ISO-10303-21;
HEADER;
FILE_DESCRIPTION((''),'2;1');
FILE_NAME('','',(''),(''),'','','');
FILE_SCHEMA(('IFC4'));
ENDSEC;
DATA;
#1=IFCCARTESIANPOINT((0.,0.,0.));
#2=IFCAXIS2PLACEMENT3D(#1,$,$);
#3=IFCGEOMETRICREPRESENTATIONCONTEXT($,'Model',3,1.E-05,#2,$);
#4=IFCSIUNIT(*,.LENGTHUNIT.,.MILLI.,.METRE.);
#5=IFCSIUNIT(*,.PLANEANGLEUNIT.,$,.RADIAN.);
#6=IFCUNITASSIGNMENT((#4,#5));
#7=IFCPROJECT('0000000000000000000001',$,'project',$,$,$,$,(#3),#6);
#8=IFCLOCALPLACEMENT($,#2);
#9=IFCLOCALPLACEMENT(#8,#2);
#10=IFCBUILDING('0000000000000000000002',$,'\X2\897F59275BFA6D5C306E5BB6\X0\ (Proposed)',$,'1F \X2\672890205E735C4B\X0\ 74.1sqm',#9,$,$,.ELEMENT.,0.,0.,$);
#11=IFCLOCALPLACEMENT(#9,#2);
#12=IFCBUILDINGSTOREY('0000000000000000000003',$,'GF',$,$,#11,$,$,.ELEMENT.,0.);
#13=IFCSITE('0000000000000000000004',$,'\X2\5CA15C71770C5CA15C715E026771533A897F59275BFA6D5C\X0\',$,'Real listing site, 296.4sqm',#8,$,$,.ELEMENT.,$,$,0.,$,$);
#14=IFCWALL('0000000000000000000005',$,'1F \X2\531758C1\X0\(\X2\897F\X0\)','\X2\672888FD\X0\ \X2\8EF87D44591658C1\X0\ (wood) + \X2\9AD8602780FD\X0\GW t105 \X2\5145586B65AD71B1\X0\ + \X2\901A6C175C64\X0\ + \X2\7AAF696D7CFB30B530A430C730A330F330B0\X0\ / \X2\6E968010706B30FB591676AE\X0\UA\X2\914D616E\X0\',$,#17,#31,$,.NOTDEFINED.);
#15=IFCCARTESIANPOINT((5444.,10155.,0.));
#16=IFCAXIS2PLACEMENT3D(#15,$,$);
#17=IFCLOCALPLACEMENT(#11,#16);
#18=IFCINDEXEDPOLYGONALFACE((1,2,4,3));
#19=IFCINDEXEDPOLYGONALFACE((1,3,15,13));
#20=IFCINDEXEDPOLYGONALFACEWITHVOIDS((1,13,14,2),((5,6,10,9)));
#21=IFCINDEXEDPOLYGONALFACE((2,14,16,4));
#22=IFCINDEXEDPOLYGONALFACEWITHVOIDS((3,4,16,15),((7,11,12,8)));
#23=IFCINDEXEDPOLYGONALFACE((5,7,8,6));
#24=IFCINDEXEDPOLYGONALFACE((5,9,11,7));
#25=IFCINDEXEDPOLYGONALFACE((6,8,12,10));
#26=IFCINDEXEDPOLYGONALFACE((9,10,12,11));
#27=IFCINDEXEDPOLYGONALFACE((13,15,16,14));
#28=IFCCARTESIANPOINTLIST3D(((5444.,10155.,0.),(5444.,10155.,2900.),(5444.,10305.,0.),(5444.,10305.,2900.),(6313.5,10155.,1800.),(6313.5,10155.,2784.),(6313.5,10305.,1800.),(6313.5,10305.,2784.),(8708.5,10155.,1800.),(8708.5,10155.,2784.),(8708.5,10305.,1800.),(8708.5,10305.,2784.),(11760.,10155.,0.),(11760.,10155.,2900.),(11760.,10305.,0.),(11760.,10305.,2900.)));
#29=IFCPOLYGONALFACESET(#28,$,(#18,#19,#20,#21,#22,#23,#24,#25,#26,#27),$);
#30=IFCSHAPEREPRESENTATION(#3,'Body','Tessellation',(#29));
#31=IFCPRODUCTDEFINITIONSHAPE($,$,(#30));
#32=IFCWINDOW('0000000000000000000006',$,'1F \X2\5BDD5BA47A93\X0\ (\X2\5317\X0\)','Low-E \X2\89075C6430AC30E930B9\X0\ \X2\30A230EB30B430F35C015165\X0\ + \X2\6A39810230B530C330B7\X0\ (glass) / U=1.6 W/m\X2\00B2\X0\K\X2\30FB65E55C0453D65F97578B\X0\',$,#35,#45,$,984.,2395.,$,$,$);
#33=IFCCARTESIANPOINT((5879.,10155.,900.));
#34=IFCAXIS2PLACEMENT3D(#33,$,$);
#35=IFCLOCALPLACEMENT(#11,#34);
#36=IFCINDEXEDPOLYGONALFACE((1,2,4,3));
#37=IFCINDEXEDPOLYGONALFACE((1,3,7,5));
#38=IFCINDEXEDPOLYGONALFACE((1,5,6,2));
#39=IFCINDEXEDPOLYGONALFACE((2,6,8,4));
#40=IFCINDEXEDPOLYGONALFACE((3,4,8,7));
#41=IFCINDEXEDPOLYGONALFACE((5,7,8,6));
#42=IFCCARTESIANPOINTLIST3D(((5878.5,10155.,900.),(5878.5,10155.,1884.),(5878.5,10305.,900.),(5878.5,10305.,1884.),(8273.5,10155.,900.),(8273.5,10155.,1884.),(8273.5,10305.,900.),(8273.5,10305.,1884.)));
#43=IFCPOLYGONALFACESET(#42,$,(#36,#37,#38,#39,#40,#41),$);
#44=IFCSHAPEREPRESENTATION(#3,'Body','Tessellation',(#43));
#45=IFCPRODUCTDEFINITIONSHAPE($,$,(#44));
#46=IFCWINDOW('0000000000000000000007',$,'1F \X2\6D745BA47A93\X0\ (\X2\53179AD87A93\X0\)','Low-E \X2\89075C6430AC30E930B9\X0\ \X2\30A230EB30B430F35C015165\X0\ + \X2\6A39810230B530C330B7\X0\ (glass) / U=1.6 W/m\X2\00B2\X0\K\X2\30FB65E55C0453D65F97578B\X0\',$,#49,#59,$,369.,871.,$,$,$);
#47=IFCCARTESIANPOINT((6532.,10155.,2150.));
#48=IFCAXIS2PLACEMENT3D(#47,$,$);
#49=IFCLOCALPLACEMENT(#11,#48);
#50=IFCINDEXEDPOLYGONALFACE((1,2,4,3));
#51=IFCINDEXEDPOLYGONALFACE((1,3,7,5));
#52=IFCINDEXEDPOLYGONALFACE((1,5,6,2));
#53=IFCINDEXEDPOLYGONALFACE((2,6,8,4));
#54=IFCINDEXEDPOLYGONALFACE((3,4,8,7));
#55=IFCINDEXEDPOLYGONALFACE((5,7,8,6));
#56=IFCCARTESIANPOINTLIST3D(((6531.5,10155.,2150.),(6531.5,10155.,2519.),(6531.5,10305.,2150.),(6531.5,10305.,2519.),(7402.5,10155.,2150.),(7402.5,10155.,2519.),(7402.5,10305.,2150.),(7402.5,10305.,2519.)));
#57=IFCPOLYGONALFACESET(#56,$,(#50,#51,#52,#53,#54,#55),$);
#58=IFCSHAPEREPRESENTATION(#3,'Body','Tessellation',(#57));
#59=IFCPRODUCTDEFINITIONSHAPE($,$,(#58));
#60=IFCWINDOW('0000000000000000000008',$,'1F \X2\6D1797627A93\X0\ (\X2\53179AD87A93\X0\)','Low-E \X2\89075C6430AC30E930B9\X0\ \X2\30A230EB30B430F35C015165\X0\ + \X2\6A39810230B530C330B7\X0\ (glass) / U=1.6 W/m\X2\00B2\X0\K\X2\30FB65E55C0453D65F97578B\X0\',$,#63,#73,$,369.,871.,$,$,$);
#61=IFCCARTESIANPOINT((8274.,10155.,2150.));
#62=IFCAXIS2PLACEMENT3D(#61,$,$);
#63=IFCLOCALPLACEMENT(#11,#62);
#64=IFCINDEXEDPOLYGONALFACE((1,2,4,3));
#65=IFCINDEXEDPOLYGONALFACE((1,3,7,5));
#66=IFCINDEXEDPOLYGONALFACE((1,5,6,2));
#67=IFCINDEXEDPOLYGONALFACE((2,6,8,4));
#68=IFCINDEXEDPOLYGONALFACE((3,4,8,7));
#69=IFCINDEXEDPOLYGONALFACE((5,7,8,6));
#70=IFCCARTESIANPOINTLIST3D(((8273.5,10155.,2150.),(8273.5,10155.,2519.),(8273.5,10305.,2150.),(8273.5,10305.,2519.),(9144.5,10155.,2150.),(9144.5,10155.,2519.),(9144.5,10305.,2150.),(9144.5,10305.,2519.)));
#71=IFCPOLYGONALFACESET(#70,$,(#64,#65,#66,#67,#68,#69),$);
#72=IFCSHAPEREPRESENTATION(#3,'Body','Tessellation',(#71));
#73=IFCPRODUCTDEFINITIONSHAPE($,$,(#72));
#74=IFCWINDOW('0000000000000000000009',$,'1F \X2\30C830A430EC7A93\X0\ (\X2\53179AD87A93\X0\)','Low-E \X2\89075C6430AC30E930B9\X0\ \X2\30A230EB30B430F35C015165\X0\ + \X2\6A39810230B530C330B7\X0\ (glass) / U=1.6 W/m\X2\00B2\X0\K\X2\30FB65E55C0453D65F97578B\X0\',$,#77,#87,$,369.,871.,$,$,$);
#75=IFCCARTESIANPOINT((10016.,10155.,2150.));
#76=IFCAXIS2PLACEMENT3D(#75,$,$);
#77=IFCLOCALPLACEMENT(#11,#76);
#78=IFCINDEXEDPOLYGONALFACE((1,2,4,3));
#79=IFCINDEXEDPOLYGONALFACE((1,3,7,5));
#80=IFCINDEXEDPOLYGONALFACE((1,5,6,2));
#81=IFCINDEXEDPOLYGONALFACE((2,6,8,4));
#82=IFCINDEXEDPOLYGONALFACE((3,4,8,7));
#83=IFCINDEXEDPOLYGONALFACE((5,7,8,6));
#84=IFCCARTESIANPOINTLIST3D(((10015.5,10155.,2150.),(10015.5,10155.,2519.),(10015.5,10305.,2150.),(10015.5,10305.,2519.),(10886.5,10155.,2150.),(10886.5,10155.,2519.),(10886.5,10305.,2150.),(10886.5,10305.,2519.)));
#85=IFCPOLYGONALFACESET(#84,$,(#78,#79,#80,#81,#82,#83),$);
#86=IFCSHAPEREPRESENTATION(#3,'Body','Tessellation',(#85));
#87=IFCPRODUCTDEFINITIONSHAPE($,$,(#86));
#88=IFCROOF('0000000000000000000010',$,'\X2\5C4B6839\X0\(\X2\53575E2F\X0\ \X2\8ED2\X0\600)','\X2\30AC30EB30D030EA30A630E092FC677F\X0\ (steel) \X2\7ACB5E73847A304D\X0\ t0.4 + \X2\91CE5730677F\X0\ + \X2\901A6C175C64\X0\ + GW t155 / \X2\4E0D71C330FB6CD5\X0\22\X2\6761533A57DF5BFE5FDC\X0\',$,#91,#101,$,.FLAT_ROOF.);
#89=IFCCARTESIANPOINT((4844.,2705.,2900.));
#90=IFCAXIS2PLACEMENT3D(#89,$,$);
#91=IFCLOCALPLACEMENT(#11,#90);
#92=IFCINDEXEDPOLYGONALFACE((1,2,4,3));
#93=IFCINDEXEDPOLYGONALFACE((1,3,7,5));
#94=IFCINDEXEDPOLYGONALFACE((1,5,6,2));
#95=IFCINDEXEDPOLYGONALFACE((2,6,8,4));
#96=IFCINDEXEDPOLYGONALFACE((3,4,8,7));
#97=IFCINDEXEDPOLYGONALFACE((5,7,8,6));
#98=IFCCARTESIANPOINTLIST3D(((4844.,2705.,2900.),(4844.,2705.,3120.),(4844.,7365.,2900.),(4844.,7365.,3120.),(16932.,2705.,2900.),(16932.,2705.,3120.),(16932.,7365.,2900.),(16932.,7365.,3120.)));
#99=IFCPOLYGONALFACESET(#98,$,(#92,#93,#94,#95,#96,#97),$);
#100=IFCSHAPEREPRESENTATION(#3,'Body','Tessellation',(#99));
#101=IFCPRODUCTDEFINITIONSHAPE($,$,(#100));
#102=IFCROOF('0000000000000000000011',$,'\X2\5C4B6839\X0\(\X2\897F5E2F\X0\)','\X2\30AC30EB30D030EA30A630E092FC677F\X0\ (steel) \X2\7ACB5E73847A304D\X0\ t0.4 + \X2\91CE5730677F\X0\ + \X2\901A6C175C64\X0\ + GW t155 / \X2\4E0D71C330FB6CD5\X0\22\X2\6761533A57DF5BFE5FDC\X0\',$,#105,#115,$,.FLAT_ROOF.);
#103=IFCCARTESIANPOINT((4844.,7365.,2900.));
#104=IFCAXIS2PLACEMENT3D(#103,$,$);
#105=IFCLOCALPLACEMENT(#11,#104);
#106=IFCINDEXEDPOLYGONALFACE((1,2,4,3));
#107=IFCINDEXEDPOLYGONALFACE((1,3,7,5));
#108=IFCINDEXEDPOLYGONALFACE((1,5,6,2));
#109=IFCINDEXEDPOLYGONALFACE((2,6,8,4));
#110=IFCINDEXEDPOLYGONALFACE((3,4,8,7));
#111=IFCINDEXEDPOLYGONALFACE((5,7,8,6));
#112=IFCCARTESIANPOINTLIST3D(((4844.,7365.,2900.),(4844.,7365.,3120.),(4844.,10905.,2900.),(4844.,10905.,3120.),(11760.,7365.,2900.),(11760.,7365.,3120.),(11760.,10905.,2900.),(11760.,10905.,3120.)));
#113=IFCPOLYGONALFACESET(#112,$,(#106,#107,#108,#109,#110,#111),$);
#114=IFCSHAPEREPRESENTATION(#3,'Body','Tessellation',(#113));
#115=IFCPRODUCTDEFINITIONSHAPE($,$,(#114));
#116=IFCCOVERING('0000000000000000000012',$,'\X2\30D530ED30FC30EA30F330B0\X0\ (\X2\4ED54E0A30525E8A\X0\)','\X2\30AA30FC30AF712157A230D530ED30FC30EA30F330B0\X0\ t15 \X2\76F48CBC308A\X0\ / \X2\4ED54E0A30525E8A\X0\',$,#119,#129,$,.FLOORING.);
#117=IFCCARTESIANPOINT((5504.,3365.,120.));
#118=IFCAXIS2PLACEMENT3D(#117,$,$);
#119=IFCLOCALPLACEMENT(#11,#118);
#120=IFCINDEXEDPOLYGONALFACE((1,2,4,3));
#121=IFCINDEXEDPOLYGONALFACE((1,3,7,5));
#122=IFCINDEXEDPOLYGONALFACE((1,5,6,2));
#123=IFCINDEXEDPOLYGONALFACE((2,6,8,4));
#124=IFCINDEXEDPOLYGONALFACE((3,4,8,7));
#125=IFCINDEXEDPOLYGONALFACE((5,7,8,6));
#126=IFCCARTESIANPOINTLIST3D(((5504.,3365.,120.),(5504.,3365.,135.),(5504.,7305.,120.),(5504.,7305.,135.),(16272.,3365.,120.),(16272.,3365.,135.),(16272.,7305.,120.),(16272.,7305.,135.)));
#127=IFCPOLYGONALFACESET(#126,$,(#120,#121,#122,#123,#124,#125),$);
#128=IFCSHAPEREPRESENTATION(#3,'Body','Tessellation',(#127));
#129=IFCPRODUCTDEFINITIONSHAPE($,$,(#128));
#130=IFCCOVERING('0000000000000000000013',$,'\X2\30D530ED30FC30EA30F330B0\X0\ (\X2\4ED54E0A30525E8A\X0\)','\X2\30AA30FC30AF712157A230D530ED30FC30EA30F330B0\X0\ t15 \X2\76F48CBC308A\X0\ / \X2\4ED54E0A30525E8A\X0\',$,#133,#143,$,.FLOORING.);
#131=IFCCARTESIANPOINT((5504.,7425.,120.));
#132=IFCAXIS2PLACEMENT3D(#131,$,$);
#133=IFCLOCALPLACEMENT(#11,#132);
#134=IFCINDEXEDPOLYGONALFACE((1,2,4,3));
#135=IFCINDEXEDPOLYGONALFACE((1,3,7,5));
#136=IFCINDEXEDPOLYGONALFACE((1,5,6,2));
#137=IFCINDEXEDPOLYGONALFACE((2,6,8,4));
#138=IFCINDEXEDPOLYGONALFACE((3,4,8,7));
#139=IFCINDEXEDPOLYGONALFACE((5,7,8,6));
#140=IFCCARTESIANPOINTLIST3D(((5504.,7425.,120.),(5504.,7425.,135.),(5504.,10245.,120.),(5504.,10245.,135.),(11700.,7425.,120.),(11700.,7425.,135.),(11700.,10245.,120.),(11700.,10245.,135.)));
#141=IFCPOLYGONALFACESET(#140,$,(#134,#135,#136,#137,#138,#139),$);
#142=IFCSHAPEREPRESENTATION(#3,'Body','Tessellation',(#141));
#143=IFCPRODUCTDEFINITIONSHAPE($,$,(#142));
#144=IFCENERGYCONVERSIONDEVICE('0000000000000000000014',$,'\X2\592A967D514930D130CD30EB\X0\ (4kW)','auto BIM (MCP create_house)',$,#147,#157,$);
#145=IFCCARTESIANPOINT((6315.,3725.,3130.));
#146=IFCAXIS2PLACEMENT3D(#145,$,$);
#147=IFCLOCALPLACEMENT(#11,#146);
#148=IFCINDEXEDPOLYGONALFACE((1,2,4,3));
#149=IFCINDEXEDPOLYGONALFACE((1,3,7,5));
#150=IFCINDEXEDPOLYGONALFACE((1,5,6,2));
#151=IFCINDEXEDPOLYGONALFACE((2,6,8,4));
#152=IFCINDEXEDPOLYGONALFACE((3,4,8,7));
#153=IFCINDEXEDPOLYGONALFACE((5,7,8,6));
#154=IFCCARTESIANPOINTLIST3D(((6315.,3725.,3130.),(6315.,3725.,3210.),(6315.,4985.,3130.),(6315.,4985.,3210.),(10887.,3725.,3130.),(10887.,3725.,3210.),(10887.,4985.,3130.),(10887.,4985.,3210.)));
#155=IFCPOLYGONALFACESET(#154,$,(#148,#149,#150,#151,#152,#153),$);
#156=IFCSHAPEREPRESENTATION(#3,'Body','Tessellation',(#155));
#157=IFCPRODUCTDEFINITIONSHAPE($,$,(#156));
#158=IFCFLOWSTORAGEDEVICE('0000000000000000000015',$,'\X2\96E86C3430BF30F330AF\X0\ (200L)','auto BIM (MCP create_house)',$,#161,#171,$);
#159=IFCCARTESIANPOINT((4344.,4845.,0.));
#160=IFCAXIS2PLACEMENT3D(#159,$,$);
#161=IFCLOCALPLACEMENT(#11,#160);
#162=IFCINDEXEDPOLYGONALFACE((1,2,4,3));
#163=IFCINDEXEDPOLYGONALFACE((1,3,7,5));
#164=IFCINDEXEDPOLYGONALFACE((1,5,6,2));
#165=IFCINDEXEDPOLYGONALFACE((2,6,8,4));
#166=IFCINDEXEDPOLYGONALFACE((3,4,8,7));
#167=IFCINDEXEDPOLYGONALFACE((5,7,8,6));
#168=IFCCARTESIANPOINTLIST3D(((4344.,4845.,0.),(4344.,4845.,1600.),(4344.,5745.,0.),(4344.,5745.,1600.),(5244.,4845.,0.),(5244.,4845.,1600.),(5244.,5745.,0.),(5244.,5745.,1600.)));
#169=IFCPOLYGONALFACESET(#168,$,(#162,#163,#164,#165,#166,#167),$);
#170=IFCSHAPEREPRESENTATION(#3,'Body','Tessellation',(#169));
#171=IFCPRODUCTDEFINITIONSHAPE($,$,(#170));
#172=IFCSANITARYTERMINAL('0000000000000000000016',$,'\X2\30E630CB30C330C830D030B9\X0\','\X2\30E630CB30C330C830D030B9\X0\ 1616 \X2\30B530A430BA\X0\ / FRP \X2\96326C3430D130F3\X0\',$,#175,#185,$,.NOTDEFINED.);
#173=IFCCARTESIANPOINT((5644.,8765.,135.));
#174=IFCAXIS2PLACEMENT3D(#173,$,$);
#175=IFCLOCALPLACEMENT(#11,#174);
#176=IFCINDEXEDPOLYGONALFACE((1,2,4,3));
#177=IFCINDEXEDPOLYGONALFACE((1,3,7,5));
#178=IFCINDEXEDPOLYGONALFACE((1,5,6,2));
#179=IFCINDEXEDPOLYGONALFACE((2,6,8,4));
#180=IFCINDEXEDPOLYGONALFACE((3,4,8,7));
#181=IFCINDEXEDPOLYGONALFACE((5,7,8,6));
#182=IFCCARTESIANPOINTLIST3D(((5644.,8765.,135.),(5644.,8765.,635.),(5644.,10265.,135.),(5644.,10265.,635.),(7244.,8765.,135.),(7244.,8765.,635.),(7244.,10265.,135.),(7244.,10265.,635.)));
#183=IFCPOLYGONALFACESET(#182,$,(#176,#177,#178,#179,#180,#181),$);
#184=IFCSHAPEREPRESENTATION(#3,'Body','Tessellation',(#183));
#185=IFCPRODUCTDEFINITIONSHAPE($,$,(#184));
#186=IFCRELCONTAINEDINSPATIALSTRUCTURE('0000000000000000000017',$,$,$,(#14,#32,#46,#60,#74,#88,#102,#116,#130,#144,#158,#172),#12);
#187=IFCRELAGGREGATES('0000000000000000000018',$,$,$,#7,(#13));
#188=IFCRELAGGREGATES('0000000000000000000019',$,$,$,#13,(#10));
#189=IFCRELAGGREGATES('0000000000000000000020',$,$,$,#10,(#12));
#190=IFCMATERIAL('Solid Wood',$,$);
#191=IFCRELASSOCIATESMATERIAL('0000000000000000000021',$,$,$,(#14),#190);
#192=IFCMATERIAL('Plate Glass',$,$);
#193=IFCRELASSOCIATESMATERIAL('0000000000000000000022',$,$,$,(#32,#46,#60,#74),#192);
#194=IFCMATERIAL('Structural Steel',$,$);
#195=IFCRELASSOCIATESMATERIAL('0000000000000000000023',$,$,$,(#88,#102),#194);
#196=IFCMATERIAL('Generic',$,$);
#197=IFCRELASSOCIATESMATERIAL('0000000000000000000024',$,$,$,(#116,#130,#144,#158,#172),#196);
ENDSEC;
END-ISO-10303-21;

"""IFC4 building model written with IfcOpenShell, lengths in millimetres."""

from ifc_helpers import new_model, si_unit, frame, frame_2d, origin, place, context, project, spatial, rectangle, extrude, material, element, fill, save


model = new_model("IFC4")

# Units and contexts
model_context = context("Model", 3, precision=1e-05, world=origin())
ifc_project = project(units=[si_unit("LENGTHUNIT", "METRE", prefix="MILLI"), si_unit("PLANEANGLEUNIT", "RADIAN")], contexts=[model_context])

# Site, building, storey
site_placement = place(None, origin())
site = spatial("IfcSite", under=ifc_project, at=site_placement, Name="岡山県岡山市東区西大寺浜", ObjectType="Real listing site, 296.4sqm", CompositionType="ELEMENT", RefElevation=0.0)
building_placement = place(site_placement, origin())
building = spatial("IfcBuilding", under=site, at=building_placement, Name="西大寺浜の家 (Proposed)", ObjectType="1F 木造平屋 74.1sqm", CompositionType="ELEMENT", ElevationOfRefHeight=0.0, ElevationOfTerrain=0.0)
storey_placement = place(building_placement, origin())
storey = spatial("IfcBuildingStorey", under=building, at=storey_placement, Name="GF", CompositionType="ELEMENT", Elevation=0.0)

# Shared definitions
ifc_material_1 = material(Name="Solid Wood")

# Shared definitions
ifc_material_2 = material(Name="Plate Glass")

# Wall, openings, windows
wall_1_placement = place(storey_placement, frame((5444.0, 10155.0, 0.0)))
wall_1 = element("IfcWall", 1, at=wall_1_placement, inside=storey, material=ifc_material_1, Name="1F 北壁(西)", Description="木製 軸組外壁 (wood) + 高性能GW t105 充填断熱 + 通気層 + 窯業系サイディング / 準耐火・外皮UA配慮", PredefinedType="NOTDEFINED", context=model_context, shape_type="SweptSolid", body=[
    extrude(rectangle(XDim=6316.0, YDim=150.0, at=frame_2d((3158.0, 75.0))), frame((5444.0, 10155.0, 0.0)), (0.0, 0.0, 1.0), 2900.0),
])
opening_1_placement = place(storey_placement, frame((5879.0, 10155.0, 900.0)))
opening_1 = element("IfcOpeningElement", 2, at=opening_1_placement, cuts=wall_1, PredefinedType="NOTDEFINED", context=model_context, shape_type="SweptSolid", body=[
    extrude(rectangle(XDim=2395.0, YDim=150.0, at=frame_2d((1197.0, 75.0))), frame((5879.0, 10155.0, 900.0)), (0.0, 0.0, 1.0), 984.0),
])
opening_2_placement = place(storey_placement, frame((6532.0, 10155.0, 2150.0)))
opening_2 = element("IfcOpeningElement", 3, at=opening_2_placement, cuts=wall_1, PredefinedType="NOTDEFINED", context=model_context, shape_type="SweptSolid", body=[
    extrude(rectangle(XDim=871.0, YDim=150.0, at=frame_2d((435.0, 75.0))), frame((6532.0, 10155.0, 2150.0)), (0.0, 0.0, 1.0), 369.0),
])
opening_3_placement = place(storey_placement, frame((8274.0, 10155.0, 2150.0)))
opening_3 = element("IfcOpeningElement", 4, at=opening_3_placement, cuts=wall_1, PredefinedType="NOTDEFINED", context=model_context, shape_type="SweptSolid", body=[
    extrude(rectangle(XDim=871.0, YDim=150.0, at=frame_2d((435.0, 75.0))), frame((8274.0, 10155.0, 2150.0)), (0.0, 0.0, 1.0), 369.0),
])
opening_4_placement = place(storey_placement, frame((10016.0, 10155.0, 2150.0)))
opening_4 = element("IfcOpeningElement", 5, at=opening_4_placement, cuts=wall_1, PredefinedType="NOTDEFINED", context=model_context, shape_type="SweptSolid", body=[
    extrude(rectangle(XDim=871.0, YDim=150.0, at=frame_2d((435.0, 75.0))), frame((10016.0, 10155.0, 2150.0)), (0.0, 0.0, 1.0), 369.0),
])
window_1_placement = place(storey_placement, frame((5879.0, 10155.0, 900.0)))
window_1 = element("IfcWindow", 6, at=window_1_placement, inside=storey, material=ifc_material_2, Name="1F 寝室窓 (北)", Description="Low-E 複層ガラス アルゴン封入 + 樹脂サッシ (glass) / U=1.6 W/m²K・日射取得型", OverallHeight=984.0, OverallWidth=2395.0, context=model_context, shape_type="SweptSolid", body=[
    extrude(rectangle(XDim=2395.0, YDim=150.0, at=frame_2d((1197.0, 75.0))), frame((5879.0, 10155.0, 900.0)), (0.0, 0.0, 1.0), 984.0),
])
fill(opening_1, window_1)
window_2_placement = place(storey_placement, frame((6532.0, 10155.0, 2150.0)))
window_2 = element("IfcWindow", 7, at=window_2_placement, inside=storey, material=ifc_material_2, Name="1F 浴室窓 (北高窓)", Description="Low-E 複層ガラス アルゴン封入 + 樹脂サッシ (glass) / U=1.6 W/m²K・日射取得型", OverallHeight=369.0, OverallWidth=871.0, context=model_context, shape_type="SweptSolid", body=[
    extrude(rectangle(XDim=871.0, YDim=150.0, at=frame_2d((435.0, 75.0))), frame((6532.0, 10155.0, 2150.0)), (0.0, 0.0, 1.0), 369.0),
])
fill(opening_2, window_2)
window_3_placement = place(storey_placement, frame((8274.0, 10155.0, 2150.0)))
window_3 = element("IfcWindow", 8, at=window_3_placement, inside=storey, material=ifc_material_2, Name="1F 洗面窓 (北高窓)", Description="Low-E 複層ガラス アルゴン封入 + 樹脂サッシ (glass) / U=1.6 W/m²K・日射取得型", OverallHeight=369.0, OverallWidth=871.0, context=model_context, shape_type="SweptSolid", body=[
    extrude(rectangle(XDim=871.0, YDim=150.0, at=frame_2d((435.0, 75.0))), frame((8274.0, 10155.0, 2150.0)), (0.0, 0.0, 1.0), 369.0),
])
fill(opening_3, window_3)
window_4_placement = place(storey_placement, frame((10016.0, 10155.0, 2150.0)))
window_4 = element("IfcWindow", 9, at=window_4_placement, inside=storey, material=ifc_material_2, Name="1F トイレ窓 (北高窓)", Description="Low-E 複層ガラス アルゴン封入 + 樹脂サッシ (glass) / U=1.6 W/m²K・日射取得型", OverallHeight=369.0, OverallWidth=871.0, context=model_context, shape_type="SweptSolid", body=[
    extrude(rectangle(XDim=871.0, YDim=150.0, at=frame_2d((435.0, 75.0))), frame((10016.0, 10155.0, 2150.0)), (0.0, 0.0, 1.0), 369.0),
])
fill(opening_4, window_4)

# Roofs
ifc_material_3 = material(Name="Structural Steel")
roof_1_placement = place(storey_placement, frame((4844.0, 2705.0, 2900.0)))
element("IfcRoof", 10, at=roof_1_placement, inside=storey, material=ifc_material_3, Name="屋根(南帯 軒600)", Description="ガルバリウム鋼板 (steel) 立平葺き t0.4 + 野地板 + 通気層 + GW t155 / 不燃・法22条区域対応", PredefinedType="FLAT_ROOF", context=model_context, shape_type="SweptSolid", body=[
    extrude(rectangle(XDim=12088.0, YDim=4660.0, at=frame_2d((6044.0, 2330.0))), frame((4844.0, 2705.0, 2900.0)), (0.0, 0.0, 1.0), 220.0),
])
roof_2_placement = place(storey_placement, frame((4844.0, 7365.0, 2900.0)))
element("IfcRoof", 11, at=roof_2_placement, inside=storey, material=ifc_material_3, Name="屋根(西帯)", Description="ガルバリウム鋼板 (steel) 立平葺き t0.4 + 野地板 + 通気層 + GW t155 / 不燃・法22条区域対応", PredefinedType="FLAT_ROOF", context=model_context, shape_type="SweptSolid", body=[
    extrude(rectangle(XDim=6916.0, YDim=3540.0, at=frame_2d((3458.0, 1770.0))), frame((4844.0, 7365.0, 2900.0)), (0.0, 0.0, 1.0), 220.0),
])

# Coverings
ifc_material_4 = material(Name="Generic")
covering_1_placement = place(storey_placement, frame((5504.0, 3365.0, 120.0)))
element("IfcCovering", 12, at=covering_1_placement, inside=storey, material=ifc_material_4, Name="フローリング (仕上げ床)", Description="オーク無垢フローリング t15 直貼り / 仕上げ床", PredefinedType="FLOORING", context=model_context, shape_type="SweptSolid", body=[
    extrude(rectangle(XDim=10768.0, YDim=3940.0, at=frame_2d((5384.0, 1970.0))), frame((5504.0, 3365.0, 120.0)), (0.0, 0.0, 1.0), 15.0),
])
covering_2_placement = place(storey_placement, frame((5504.0, 7425.0, 120.0)))
element("IfcCovering", 13, at=covering_2_placement, inside=storey, material=ifc_material_4, Name="フローリング (仕上げ床)", Description="オーク無垢フローリング t15 直貼り / 仕上げ床", PredefinedType="FLOORING", context=model_context, shape_type="SweptSolid", body=[
    extrude(rectangle(XDim=6196.0, YDim=2820.0, at=frame_2d((3098.0, 1410.0))), frame((5504.0, 7425.0, 120.0)), (0.0, 0.0, 1.0), 15.0),
])

# Energy conversion device
energy_conversion_device_placement = place(storey_placement, frame((6315.0, 3725.0, 3130.0)))
element("IfcEnergyConversionDevice", 14, at=energy_conversion_device_placement, inside=storey, material=ifc_material_4, Name="太陽光パネル (4kW)", Description="auto BIM (MCP create_house)", context=model_context, shape_type="SweptSolid", body=[
    extrude(rectangle(XDim=4572.0, YDim=1260.0, at=frame_2d((2286.0, 630.0))), frame((6315.0, 3725.0, 3130.0)), (0.0, 0.0, 1.0), 80.0),
])

# Flow storage device
flow_storage_device_placement = place(storey_placement, frame((4344.0, 4845.0, 0.0)))
element("IfcFlowStorageDevice", 15, at=flow_storage_device_placement, inside=storey, material=ifc_material_4, Name="雨水タンク (200L)", Description="auto BIM (MCP create_house)", context=model_context, shape_type="SweptSolid", body=[
    extrude(rectangle(XDim=900.0, YDim=900.0, at=frame_2d((450.0, 450.0))), frame((4344.0, 4845.0, 0.0)), (0.0, 0.0, 1.0), 1600.0),
])

# Sanitary terminal
sanitary_terminal_placement = place(storey_placement, frame((5644.0, 8765.0, 135.0)))
element("IfcSanitaryTerminal", 16, at=sanitary_terminal_placement, inside=storey, material=ifc_material_4, Name="ユニットバス", Description="ユニットバス 1616 サイズ / FRP 防水パン", PredefinedType="NOTDEFINED", context=model_context, shape_type="SweptSolid", body=[
    extrude(rectangle(XDim=1600.0, YDim=1500.0, at=frame_2d((800.0, 750.0))), frame((5644.0, 8765.0, 135.0)), (0.0, 0.0, 1.0), 500.0),
])

save(model, "model.ifc")
